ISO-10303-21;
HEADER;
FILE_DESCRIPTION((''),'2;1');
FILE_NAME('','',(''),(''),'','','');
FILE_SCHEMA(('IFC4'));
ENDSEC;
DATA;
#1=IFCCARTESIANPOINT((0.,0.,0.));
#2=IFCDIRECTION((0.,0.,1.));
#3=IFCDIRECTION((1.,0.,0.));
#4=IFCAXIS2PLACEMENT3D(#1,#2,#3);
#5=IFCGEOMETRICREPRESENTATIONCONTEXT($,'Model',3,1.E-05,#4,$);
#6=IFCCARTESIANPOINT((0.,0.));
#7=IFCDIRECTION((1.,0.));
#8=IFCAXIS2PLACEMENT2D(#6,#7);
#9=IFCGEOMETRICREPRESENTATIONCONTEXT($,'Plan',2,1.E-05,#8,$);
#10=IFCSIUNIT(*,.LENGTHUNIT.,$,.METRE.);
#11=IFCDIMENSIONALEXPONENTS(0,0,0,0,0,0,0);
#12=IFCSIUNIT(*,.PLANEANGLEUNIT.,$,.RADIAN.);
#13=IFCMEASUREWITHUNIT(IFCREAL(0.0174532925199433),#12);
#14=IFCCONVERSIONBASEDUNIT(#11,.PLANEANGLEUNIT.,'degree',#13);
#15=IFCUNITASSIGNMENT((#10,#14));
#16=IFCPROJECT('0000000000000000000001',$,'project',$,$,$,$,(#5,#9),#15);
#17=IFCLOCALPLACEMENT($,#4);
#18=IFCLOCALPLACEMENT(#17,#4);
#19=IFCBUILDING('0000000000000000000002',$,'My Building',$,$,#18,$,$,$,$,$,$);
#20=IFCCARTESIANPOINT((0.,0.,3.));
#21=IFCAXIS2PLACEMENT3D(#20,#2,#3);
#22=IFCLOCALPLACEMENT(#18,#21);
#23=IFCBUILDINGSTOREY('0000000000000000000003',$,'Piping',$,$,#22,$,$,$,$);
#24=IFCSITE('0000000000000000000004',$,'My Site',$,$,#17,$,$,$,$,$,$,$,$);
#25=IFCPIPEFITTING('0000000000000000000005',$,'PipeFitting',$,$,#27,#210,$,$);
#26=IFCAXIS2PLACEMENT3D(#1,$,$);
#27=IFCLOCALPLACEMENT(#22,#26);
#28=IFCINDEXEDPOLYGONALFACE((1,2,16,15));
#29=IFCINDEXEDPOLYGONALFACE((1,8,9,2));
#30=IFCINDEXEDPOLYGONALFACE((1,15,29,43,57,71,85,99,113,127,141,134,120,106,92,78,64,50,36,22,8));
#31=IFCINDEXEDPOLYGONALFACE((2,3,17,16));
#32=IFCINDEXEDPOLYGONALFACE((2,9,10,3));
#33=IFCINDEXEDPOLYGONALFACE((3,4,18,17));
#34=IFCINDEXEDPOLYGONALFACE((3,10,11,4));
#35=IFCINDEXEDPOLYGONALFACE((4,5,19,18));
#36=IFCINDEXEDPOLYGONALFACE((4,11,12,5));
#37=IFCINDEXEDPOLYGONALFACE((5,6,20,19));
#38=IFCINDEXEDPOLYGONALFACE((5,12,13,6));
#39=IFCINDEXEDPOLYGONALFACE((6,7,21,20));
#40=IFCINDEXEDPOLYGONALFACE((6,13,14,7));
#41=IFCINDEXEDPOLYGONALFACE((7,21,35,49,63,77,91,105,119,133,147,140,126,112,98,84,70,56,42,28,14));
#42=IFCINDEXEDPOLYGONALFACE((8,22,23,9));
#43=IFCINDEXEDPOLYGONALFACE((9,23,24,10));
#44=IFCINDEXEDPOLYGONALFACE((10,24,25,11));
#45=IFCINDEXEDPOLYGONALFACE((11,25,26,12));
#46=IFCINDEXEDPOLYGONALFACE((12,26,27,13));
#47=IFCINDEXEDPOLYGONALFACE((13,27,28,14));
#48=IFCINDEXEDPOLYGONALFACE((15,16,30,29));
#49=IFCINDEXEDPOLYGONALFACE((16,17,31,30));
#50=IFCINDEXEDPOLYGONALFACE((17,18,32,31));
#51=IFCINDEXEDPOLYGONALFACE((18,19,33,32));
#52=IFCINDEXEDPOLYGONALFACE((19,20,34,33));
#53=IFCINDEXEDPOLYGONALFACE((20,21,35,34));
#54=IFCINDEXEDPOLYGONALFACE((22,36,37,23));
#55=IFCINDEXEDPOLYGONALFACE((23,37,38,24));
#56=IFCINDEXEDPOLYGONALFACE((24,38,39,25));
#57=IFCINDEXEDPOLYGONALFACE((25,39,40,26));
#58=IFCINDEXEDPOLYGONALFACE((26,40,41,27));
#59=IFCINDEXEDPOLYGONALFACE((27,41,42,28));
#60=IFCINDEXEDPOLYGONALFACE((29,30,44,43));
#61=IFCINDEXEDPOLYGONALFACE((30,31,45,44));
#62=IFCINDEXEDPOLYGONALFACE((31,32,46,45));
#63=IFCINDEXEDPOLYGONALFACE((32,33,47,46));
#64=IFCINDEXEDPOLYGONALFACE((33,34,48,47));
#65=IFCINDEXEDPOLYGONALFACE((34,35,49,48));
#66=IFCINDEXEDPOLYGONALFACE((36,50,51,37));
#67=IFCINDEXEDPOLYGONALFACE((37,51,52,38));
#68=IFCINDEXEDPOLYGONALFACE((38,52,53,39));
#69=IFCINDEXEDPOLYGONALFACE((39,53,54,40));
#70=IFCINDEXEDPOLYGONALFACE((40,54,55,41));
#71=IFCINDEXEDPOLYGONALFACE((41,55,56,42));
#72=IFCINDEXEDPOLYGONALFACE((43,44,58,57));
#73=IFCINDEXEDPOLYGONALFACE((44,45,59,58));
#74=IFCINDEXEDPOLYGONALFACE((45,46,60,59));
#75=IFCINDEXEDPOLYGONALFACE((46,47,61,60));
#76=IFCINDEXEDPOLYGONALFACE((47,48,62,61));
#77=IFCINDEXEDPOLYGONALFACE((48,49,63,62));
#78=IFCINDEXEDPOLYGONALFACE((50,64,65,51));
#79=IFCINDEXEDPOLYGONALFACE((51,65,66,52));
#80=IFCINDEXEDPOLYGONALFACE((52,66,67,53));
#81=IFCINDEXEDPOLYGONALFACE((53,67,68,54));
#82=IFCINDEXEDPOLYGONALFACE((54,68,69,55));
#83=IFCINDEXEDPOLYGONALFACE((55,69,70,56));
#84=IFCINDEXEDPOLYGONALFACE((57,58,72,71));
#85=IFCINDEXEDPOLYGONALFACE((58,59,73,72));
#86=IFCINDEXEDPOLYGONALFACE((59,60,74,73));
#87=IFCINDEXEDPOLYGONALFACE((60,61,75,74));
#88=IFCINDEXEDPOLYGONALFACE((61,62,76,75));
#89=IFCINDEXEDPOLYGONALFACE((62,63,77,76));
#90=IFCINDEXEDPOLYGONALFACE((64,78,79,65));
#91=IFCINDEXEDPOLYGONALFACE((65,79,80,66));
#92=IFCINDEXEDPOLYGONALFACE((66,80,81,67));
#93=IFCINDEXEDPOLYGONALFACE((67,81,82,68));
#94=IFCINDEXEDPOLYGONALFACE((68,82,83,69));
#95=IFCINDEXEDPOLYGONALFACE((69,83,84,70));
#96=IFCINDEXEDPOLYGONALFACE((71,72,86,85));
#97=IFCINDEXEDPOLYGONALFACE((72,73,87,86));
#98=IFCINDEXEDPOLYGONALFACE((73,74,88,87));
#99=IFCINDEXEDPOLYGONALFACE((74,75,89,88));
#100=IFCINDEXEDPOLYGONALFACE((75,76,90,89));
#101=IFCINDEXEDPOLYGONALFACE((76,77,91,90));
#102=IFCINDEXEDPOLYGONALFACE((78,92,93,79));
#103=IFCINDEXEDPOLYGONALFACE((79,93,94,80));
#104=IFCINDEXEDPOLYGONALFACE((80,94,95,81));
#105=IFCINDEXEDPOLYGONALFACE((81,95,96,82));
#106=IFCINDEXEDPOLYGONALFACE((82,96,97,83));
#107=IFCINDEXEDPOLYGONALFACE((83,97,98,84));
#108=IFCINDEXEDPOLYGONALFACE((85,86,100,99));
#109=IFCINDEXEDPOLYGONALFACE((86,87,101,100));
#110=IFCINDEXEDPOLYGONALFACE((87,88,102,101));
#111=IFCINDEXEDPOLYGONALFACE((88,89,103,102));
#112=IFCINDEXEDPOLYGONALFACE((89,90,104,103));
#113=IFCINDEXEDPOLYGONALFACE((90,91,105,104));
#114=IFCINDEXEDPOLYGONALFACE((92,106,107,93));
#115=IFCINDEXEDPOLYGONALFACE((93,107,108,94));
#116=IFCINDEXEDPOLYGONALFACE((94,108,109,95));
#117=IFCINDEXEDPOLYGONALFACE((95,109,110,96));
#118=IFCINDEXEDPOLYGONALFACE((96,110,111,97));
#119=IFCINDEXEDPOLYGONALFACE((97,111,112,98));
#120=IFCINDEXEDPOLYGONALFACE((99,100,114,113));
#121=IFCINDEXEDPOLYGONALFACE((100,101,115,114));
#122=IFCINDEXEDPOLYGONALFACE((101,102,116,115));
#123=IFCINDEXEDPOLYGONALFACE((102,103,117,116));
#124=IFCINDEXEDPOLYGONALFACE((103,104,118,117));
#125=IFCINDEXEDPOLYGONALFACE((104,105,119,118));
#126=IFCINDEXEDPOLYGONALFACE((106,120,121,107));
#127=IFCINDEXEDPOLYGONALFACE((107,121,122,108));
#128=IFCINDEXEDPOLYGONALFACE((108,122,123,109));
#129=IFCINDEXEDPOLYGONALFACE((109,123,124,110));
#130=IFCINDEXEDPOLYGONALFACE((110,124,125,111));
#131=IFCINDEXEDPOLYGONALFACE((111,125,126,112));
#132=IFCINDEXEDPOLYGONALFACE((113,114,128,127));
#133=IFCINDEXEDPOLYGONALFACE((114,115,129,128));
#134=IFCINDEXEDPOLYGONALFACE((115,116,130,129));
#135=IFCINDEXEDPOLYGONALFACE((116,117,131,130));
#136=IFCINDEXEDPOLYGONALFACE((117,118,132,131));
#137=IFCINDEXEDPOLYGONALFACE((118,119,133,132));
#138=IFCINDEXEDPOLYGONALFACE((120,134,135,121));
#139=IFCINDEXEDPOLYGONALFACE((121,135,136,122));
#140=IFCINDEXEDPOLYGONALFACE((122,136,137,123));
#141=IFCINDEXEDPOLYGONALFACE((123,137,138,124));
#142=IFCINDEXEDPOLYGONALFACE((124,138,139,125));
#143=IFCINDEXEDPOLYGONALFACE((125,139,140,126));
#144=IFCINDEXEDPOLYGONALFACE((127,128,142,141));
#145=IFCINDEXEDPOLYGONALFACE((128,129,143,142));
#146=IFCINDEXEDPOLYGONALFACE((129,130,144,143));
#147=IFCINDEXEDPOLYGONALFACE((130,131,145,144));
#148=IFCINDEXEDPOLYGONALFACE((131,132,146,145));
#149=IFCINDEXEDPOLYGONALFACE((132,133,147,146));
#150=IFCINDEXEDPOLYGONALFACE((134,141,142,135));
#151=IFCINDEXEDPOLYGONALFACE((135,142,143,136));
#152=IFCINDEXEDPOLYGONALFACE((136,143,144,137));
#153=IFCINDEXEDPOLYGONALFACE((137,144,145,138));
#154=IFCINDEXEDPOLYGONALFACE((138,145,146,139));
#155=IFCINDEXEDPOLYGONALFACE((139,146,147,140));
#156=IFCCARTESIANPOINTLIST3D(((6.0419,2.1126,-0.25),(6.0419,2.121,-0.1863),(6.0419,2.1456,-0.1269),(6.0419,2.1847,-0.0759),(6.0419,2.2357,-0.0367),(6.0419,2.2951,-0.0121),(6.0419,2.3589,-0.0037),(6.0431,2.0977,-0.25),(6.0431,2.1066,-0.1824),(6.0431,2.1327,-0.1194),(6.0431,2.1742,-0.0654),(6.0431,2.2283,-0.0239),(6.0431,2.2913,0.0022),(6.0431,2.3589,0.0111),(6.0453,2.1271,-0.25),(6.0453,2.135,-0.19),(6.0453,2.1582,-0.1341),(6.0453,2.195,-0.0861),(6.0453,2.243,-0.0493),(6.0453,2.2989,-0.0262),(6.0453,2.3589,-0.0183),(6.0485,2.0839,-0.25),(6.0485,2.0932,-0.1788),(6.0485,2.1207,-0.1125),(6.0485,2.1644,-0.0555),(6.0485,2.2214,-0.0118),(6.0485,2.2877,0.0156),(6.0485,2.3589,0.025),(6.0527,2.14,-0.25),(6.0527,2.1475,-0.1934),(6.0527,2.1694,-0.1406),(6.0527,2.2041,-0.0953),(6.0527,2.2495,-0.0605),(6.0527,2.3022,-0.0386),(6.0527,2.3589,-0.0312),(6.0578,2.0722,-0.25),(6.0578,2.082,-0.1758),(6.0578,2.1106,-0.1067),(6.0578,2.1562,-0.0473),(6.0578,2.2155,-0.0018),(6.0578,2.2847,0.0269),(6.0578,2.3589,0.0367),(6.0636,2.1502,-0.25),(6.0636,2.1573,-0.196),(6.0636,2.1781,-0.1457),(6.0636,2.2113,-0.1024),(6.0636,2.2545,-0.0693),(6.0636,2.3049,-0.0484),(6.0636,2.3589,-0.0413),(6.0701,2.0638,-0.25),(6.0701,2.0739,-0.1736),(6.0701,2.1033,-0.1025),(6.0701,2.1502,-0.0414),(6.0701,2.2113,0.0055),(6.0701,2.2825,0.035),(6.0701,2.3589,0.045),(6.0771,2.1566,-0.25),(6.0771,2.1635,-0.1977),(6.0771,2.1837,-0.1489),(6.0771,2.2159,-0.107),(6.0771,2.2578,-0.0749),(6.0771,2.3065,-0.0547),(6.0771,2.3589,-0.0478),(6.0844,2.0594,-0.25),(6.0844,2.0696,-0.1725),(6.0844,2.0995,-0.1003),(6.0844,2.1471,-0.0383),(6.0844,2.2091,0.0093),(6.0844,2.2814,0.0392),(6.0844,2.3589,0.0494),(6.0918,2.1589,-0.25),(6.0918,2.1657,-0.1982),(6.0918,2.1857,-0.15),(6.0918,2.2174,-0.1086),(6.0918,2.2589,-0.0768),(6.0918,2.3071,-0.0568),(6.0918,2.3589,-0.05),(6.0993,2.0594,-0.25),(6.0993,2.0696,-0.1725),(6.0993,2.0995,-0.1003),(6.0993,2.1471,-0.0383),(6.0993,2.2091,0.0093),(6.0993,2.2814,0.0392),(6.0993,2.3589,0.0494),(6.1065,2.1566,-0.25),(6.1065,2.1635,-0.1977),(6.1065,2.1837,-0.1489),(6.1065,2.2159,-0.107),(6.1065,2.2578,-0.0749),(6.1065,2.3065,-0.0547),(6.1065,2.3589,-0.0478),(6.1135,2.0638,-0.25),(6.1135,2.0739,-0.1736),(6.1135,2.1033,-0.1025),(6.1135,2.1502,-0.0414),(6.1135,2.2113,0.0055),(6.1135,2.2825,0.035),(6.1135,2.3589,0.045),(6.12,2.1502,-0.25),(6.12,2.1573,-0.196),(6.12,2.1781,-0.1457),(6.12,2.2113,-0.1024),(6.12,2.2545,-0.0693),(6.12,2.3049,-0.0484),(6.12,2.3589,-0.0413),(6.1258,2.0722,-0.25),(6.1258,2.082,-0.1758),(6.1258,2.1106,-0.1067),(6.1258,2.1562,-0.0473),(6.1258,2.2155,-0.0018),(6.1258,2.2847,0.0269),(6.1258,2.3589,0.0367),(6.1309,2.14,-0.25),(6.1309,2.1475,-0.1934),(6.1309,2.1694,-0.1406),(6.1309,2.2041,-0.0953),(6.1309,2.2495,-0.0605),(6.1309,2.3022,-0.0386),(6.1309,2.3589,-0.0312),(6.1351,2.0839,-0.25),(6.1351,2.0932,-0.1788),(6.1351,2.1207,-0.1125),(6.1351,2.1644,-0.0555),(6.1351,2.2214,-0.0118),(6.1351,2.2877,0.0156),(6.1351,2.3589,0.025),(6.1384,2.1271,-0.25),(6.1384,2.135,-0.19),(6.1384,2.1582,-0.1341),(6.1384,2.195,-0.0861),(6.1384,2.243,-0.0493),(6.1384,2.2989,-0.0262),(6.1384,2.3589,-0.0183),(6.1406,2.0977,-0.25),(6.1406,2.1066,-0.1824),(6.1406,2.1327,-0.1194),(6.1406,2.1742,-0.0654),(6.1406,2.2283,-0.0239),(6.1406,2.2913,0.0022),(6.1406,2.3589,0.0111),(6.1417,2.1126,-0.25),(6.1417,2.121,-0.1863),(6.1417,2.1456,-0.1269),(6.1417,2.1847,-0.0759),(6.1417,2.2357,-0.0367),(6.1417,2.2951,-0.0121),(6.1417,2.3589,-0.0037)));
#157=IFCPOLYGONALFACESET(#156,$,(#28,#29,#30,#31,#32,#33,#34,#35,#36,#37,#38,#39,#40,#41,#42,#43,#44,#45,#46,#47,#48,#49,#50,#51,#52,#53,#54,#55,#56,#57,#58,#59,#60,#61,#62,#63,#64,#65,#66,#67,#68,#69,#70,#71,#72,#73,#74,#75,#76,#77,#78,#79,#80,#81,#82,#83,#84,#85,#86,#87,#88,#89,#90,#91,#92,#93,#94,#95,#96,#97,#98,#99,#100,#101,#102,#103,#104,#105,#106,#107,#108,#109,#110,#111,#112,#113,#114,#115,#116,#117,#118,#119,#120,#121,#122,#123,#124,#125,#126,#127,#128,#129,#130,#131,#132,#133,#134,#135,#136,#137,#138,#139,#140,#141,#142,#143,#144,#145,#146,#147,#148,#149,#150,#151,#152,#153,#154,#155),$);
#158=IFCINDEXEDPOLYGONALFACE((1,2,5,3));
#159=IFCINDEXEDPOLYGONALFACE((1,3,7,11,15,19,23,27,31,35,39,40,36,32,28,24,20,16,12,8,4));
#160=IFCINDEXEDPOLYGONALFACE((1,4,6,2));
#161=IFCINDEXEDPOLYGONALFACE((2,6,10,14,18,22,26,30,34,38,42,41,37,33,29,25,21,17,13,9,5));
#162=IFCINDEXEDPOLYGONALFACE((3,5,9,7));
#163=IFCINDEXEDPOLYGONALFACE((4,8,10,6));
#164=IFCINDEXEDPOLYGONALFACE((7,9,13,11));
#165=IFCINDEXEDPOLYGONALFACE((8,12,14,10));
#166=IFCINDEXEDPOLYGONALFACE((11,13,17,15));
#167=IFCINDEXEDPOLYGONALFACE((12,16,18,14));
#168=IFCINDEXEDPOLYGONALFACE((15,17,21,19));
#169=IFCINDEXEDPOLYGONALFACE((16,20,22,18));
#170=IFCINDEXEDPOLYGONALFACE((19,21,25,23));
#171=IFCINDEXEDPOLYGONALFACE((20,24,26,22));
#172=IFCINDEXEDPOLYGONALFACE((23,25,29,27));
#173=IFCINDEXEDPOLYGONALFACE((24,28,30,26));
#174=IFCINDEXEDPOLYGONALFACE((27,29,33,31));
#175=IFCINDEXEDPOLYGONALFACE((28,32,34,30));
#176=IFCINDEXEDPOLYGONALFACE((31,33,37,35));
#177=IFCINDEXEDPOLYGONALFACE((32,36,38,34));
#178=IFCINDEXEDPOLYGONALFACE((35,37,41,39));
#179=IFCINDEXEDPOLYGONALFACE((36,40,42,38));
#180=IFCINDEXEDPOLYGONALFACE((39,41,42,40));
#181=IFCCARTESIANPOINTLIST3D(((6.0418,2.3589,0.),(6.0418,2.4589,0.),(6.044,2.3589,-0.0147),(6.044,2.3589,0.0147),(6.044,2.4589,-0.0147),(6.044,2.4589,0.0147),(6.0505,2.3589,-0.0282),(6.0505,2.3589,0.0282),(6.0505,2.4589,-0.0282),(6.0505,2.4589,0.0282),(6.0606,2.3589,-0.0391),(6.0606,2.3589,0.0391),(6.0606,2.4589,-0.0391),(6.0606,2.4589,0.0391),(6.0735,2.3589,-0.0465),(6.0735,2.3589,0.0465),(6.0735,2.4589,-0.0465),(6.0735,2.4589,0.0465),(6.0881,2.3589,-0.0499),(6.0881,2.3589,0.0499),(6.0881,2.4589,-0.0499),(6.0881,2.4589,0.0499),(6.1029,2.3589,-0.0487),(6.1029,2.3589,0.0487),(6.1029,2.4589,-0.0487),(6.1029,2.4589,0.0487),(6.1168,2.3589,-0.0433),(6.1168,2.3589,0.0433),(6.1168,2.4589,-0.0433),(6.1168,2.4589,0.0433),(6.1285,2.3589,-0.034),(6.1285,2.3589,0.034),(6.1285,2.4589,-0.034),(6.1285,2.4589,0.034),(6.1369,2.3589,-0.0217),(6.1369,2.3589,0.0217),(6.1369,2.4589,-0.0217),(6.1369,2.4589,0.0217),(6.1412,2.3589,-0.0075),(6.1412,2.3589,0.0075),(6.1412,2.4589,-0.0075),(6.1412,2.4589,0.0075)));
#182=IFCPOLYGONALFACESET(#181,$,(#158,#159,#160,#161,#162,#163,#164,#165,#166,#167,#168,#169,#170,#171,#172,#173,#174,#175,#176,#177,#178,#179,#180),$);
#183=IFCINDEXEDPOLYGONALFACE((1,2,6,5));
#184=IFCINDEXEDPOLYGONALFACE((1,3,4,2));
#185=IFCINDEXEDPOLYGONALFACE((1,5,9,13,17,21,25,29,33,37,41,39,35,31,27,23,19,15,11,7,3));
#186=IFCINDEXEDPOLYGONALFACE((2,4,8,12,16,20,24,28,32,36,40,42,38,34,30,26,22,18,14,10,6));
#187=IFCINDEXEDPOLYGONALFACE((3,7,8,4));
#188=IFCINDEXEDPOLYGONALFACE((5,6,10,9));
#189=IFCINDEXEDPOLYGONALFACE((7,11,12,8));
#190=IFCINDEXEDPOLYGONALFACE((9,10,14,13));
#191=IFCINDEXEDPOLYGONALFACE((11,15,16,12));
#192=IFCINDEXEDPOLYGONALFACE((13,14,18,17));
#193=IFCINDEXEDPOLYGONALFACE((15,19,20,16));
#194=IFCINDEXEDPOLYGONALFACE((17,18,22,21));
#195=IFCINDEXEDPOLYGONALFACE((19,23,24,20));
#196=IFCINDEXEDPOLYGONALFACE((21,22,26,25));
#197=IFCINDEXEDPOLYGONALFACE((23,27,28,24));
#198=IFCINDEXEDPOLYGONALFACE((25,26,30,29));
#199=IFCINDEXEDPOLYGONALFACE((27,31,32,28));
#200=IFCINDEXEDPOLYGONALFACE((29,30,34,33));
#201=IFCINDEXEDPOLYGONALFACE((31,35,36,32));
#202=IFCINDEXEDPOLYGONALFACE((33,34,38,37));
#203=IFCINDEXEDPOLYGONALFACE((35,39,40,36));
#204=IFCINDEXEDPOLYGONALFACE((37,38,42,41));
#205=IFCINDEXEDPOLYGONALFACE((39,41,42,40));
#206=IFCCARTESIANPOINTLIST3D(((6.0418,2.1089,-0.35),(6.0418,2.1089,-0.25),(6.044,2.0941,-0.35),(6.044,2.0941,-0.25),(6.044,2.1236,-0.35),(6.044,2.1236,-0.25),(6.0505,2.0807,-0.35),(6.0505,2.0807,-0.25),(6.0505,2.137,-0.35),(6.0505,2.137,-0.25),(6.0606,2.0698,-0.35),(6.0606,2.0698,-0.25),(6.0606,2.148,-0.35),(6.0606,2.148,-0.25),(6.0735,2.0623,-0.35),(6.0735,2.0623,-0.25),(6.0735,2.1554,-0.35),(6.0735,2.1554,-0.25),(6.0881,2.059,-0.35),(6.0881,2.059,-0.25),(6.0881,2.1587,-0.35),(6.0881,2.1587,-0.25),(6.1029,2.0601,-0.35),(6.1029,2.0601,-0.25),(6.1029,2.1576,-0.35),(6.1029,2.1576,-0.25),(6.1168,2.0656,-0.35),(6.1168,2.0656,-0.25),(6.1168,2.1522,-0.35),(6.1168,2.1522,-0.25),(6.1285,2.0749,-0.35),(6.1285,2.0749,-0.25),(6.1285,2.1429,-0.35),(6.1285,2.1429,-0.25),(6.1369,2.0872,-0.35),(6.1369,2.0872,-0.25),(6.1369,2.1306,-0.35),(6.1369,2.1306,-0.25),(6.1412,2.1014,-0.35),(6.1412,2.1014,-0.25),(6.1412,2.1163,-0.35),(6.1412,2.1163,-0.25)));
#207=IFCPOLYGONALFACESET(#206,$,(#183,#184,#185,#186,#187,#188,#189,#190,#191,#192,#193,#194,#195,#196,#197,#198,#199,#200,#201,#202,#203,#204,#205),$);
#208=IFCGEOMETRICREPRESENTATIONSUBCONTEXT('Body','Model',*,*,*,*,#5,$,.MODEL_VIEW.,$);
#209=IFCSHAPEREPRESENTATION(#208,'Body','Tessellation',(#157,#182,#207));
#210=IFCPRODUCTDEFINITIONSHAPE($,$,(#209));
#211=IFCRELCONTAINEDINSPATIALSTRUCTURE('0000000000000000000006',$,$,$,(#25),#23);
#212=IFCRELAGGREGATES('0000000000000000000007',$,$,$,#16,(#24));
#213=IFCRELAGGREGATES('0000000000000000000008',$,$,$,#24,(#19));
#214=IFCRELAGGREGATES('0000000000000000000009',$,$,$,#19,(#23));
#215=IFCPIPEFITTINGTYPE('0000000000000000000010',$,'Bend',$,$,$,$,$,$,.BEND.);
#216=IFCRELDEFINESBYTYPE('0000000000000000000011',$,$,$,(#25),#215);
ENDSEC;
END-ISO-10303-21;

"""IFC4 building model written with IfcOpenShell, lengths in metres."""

from ifc_helpers import new_model, entity, si_unit, converted_unit, frame, origin_with_axes, origin_2d_with_axis, place, context, subcontext, project, spatial, circle, extrude, source, transform, mapped, type_object, type_shapes, element, save


model = new_model("IFC4")

# Units and contexts
model_context = context("Model", 3, precision=1e-05, world=origin_with_axes())
plan_context = context("Plan", 2, precision=1e-05, world=origin_2d_with_axis())
body_context = subcontext(model_context, "Body", "Model", "MODEL_VIEW")
ifc_project = project(units=[si_unit("LENGTHUNIT", "METRE"), converted_unit("PLANEANGLEUNIT", "degree", entity("IfcReal", 0.0174532925199433), si_unit("PLANEANGLEUNIT", "RADIAN"), dimensions=[0, 0, 0, 0, 0, 0, 0])], contexts=[model_context, plan_context])

# Site, building, storey
site_placement = place(None, origin_with_axes())
site = spatial("IfcSite", under=ifc_project, at=site_placement, Name="My Site")
building_placement = place(site_placement, origin_with_axes())
building = spatial("IfcBuilding", under=site, at=building_placement, Name="My Building")
storey_placement = place(building_placement, frame((0.0, 0.0, 3.0), z_axis=(0.0, 0.0, 1.0), x_axis=(1.0, 0.0, 0.0)))
storey = spatial("IfcBuildingStorey", under=building, at=storey_placement, Name="Piping")

# Shared definitions
pipe_fitting_type = type_object("IfcPipeFittingType", Name="Bend", PredefinedType="BEND")
shared_shape = source(origin_with_axes(), body_context, "Body", "SolidModel", [
    entity("IfcSweptDiskSolid", entity("IfcIndexedPolyCurve", entity("IfcCartesianPointList3D", [[0.0, 0.0, -0.1], [0.0, -0.0732, -0.2768], [0.0, -0.25, -0.35]]), [entity("IfcArcIndex", [1, 2, 3])]), 0.05),
    extrude(circle(Radius=0.05), origin_with_axes(), (0.0, 0.0, -1.0), 0.1),
    extrude(circle(Radius=0.05), frame((0.0, -0.25, -0.35), z_axis=(0.0, -1.0, 0.0), x_axis=(1.0, 0.0, 0.0)), (0.0, 0.0, 1.0), 0.1),
])
type_shapes(pipe_fitting_type, [shared_shape])

# Pipe fitting
for number, where, z_axis, x_axis, name in (
    (1, (6.0918, 2.4589, 0.0), (0.0, 1.0, 0.0), (-1.0, 0.0, 0.0), "PipeFitting"),
):
    element("IfcPipeFitting", number, at=place(storey_placement, frame(where, z_axis=z_axis, x_axis=x_axis)), inside=storey, type_object=pipe_fitting_type, Name=name, context=body_context, shape_type="MappedRepresentation", body=[
        mapped(shared_shape, transform((0.0, 0.0, 0.0), x_axis=(1.0, 0.0, 0.0), y_axis=(0.0, 1.0, 0.0), z_axis=(0.0, 0.0, 1.0), scale=1.0)),
    ])

save(model, "model.ifc")
